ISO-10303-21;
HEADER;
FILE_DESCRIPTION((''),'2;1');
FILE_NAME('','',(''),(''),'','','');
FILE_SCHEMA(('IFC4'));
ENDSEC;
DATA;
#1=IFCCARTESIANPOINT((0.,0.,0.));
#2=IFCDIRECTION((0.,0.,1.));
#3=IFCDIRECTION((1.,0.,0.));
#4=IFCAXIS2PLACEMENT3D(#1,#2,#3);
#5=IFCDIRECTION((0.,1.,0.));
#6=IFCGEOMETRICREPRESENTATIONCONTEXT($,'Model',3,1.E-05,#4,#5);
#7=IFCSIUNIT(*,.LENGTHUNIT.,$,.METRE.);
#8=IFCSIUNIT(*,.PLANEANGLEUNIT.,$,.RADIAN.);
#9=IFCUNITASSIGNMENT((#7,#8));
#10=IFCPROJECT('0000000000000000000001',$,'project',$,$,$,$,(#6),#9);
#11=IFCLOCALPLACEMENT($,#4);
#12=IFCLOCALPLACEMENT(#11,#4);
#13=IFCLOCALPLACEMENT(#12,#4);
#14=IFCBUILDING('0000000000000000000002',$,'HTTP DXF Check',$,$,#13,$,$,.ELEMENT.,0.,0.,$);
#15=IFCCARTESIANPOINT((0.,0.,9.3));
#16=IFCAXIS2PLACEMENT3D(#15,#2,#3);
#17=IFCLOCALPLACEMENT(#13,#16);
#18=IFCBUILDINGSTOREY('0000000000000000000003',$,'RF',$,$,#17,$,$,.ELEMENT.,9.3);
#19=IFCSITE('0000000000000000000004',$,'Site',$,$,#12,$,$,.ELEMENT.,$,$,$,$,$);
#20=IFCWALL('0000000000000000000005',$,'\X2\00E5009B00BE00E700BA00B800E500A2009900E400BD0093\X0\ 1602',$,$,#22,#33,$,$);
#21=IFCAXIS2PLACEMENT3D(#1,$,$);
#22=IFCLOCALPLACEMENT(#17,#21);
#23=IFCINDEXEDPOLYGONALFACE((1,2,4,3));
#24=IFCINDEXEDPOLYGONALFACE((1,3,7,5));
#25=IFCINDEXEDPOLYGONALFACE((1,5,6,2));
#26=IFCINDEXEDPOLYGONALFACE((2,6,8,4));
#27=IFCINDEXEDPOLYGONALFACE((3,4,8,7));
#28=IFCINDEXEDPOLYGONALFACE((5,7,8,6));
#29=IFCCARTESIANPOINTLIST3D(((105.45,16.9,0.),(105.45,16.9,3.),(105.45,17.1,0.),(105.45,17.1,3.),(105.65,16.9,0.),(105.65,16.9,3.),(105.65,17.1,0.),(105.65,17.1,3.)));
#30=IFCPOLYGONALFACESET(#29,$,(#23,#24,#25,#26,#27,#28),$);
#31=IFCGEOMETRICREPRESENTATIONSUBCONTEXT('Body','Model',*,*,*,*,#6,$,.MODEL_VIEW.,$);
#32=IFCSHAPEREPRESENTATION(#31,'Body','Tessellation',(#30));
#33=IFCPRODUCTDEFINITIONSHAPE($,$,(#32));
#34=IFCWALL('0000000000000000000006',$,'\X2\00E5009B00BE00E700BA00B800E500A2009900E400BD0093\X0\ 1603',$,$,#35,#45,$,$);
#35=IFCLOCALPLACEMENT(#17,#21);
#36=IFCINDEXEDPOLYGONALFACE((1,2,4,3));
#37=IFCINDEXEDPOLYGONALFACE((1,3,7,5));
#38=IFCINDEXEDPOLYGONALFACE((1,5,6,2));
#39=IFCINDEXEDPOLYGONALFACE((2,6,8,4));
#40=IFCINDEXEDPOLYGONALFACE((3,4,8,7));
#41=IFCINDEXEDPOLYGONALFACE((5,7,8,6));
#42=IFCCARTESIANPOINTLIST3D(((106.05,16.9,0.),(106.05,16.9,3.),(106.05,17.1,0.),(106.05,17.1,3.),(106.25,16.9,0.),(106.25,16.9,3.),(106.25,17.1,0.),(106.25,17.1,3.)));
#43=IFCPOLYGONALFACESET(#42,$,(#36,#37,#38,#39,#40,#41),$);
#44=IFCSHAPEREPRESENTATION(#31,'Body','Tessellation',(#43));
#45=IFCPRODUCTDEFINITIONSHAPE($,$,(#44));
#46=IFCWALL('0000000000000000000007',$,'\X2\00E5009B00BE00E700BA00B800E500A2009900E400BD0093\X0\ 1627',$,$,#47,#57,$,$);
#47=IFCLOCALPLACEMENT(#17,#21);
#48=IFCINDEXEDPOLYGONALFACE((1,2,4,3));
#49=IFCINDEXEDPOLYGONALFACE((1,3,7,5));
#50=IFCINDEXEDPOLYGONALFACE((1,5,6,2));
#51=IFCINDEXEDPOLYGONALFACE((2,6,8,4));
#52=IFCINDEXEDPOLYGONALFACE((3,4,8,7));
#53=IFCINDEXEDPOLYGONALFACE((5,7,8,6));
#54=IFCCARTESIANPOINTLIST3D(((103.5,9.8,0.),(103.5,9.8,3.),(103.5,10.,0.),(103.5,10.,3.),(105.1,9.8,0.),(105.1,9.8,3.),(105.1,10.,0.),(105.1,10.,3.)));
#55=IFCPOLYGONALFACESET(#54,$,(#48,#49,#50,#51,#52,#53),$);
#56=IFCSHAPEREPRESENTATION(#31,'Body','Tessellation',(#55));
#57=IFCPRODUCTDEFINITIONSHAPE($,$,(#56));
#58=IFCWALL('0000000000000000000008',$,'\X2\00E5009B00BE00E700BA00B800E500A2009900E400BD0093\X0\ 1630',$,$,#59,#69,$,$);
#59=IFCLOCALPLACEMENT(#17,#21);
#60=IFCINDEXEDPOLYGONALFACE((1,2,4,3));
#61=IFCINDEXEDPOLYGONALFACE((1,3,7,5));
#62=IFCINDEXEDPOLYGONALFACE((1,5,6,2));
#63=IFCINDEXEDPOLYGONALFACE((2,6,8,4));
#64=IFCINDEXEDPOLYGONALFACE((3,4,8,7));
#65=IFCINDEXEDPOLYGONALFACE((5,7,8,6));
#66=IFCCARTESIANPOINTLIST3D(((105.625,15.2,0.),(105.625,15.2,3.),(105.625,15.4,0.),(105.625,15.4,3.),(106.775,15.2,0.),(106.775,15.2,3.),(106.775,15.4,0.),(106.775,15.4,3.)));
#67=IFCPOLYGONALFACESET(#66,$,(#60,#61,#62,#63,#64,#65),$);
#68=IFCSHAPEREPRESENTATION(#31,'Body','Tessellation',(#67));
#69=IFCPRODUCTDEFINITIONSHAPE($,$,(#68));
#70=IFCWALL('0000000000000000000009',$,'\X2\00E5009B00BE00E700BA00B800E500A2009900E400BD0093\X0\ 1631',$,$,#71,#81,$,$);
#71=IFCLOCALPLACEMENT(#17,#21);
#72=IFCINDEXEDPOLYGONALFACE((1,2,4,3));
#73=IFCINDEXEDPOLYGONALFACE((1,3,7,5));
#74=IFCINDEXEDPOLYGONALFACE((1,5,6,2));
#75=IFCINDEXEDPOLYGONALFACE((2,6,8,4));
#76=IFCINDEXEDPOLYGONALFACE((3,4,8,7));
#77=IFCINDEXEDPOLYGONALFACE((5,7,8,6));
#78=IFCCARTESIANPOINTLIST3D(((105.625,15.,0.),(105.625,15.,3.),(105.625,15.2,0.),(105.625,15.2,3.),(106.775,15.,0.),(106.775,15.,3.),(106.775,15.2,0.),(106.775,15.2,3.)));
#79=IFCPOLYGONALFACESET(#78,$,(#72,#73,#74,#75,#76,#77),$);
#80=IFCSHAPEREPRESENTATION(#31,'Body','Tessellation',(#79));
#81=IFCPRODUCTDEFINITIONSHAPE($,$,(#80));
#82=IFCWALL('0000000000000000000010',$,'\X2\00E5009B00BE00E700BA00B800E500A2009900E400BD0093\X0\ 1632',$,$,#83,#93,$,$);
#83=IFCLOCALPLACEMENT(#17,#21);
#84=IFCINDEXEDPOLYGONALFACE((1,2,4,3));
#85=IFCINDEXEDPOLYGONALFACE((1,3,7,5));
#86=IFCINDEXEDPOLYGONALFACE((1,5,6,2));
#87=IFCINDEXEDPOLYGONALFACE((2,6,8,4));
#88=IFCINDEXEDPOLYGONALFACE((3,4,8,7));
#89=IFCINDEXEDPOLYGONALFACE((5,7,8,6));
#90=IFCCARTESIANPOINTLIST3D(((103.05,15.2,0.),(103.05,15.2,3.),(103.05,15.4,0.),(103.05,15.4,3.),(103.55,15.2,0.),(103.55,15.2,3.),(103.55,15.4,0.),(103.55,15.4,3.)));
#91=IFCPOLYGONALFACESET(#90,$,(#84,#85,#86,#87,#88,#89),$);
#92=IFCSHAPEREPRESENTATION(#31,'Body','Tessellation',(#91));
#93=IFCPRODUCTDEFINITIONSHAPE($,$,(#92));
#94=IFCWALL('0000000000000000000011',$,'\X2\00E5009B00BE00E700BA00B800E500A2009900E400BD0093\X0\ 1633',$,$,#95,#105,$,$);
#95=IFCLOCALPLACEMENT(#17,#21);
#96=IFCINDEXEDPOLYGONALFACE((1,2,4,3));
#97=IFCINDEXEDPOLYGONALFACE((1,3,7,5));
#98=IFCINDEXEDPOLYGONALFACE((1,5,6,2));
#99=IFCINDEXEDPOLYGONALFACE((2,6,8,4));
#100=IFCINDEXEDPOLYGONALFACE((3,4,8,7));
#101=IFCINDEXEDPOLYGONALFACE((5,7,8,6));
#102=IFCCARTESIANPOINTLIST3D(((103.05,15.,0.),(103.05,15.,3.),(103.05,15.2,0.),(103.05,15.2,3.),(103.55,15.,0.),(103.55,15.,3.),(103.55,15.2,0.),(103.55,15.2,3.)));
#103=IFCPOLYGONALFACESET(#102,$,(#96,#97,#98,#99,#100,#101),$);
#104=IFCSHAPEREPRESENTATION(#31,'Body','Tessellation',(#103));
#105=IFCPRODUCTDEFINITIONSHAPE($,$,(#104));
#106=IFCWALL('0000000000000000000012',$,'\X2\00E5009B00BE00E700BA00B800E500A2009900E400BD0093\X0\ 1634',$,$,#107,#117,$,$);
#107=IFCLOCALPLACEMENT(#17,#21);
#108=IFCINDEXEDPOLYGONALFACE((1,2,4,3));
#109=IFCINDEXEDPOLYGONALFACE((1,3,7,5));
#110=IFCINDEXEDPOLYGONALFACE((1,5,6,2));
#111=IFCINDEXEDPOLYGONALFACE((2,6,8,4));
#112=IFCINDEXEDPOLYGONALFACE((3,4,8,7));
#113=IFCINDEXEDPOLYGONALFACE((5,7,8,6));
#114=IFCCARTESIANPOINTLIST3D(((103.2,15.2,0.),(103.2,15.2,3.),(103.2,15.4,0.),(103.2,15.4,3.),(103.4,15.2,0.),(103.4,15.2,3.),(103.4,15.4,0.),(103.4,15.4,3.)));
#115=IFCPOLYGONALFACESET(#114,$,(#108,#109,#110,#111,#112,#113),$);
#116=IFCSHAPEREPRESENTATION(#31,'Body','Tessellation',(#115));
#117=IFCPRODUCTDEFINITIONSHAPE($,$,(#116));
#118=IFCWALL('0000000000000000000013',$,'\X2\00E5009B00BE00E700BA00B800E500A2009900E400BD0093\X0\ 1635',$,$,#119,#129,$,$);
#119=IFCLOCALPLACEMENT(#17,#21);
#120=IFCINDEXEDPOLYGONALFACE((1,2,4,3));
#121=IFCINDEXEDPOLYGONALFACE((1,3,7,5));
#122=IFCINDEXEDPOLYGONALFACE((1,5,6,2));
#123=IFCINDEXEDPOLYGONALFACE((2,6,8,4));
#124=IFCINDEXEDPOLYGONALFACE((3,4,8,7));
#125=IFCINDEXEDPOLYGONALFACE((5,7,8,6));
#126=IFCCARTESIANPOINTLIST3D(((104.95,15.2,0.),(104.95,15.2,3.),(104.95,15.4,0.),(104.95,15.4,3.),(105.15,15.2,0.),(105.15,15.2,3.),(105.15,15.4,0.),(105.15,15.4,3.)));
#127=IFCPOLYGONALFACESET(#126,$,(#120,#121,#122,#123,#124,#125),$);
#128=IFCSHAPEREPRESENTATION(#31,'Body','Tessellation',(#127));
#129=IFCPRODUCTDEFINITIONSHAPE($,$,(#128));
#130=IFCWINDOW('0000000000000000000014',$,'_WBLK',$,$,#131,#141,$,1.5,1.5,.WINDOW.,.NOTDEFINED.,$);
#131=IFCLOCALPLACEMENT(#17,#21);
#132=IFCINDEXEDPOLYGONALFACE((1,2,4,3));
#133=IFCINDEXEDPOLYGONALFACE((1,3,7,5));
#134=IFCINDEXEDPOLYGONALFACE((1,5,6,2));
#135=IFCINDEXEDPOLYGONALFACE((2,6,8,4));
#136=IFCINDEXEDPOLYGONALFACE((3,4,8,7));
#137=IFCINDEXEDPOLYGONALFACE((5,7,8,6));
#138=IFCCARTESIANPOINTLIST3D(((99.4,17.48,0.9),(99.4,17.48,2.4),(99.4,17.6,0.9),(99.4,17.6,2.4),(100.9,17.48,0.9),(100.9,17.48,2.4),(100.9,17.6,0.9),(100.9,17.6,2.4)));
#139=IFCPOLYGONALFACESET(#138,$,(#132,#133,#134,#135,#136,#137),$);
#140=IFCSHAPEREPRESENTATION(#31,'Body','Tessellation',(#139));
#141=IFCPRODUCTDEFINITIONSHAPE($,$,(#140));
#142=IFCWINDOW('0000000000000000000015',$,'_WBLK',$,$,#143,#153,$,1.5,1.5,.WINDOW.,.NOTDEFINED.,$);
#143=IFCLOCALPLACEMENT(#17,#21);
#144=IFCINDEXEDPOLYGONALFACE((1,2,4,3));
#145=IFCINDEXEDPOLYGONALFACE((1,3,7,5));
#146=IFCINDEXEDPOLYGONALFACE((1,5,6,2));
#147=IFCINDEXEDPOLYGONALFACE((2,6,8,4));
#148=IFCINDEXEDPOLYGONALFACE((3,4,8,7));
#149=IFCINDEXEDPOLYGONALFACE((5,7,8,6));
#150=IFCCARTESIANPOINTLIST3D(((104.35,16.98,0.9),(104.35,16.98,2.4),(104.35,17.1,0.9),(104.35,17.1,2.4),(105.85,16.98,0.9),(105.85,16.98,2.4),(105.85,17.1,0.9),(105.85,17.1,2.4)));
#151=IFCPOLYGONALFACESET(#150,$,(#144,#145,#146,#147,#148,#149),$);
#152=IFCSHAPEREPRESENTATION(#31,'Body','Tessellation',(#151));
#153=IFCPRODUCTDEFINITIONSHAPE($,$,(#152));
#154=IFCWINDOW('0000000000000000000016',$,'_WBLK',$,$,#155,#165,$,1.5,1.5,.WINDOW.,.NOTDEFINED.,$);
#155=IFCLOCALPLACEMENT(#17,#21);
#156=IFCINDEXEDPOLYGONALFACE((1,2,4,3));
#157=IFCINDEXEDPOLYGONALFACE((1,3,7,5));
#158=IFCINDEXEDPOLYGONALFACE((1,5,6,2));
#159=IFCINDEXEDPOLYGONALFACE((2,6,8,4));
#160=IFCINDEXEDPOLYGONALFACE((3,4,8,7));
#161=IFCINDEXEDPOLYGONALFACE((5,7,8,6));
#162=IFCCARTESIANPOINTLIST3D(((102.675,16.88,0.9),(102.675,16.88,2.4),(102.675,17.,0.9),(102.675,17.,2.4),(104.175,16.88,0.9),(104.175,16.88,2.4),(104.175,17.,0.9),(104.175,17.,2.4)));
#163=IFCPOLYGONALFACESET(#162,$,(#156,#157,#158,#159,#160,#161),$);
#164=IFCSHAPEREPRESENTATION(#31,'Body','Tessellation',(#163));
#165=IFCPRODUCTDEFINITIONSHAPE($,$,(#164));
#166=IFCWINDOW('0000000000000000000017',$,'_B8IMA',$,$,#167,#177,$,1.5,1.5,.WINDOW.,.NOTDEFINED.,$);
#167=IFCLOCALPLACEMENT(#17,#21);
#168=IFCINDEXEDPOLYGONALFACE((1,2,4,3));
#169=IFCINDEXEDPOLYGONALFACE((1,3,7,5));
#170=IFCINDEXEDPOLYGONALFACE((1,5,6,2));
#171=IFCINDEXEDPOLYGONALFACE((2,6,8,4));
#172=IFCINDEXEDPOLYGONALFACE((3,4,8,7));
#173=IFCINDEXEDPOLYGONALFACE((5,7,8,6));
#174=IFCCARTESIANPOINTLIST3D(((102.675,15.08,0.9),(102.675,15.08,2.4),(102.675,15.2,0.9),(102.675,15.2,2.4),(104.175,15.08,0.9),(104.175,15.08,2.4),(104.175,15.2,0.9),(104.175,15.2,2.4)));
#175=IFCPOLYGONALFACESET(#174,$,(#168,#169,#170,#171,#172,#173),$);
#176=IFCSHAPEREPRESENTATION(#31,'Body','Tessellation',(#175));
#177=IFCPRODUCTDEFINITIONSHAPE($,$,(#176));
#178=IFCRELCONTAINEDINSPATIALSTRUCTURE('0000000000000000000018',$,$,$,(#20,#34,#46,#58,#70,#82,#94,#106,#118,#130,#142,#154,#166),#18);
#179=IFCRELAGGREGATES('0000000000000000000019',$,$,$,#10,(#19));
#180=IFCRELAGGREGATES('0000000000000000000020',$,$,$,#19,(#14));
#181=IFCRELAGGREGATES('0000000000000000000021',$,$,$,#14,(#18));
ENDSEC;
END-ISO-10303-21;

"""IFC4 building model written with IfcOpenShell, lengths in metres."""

from ifc_helpers import new_model, si_unit, direction, frame, frame_2d, origin_with_axes, place, context, subcontext, project, spatial, rectangle, extrude, element, save


model = new_model("IFC4")

# Units and contexts
model_context = context("Model", 3, precision=1e-05, world=origin_with_axes(), true_north=direction((0.0, 1.0, 0.0)))
body_context = subcontext(model_context, "Body", "Model", "MODEL_VIEW")
ifc_project = project(units=[si_unit("LENGTHUNIT", "METRE"), si_unit("PLANEANGLEUNIT", "RADIAN")], contexts=[model_context])

# Site, building, storey
placement = place(None, origin_with_axes())
site_placement = place(placement, origin_with_axes())
site = spatial("IfcSite", under=ifc_project, at=site_placement, Name="Site", CompositionType="ELEMENT")
building_placement = place(site_placement, origin_with_axes())
building = spatial("IfcBuilding", under=site, at=building_placement, Name="HTTP DXF Check", CompositionType="ELEMENT", ElevationOfRefHeight=0.0, ElevationOfTerrain=0.0)
storey_placement = place(building_placement, frame((0.0, 0.0, 9.3), z_axis=(0.0, 0.0, 1.0), x_axis=(1.0, 0.0, 0.0)))
storey = spatial("IfcBuildingStorey", under=building, at=storey_placement, Name="RF", CompositionType="ELEMENT", Elevation=9.3)

# Walls
for number, where, z_axis, x_axis, name in (
    (1, (105.55, 17.0, 0.0), (0.0, 0.0, 1.0), (0.0, 1.0, 0.0), "å\u009b¾çº¸å¢\u0099ä½\u0093 1602"),
    (2, (106.15, 17.0, 0.0), (0.0, 0.0, 1.0), (0.0, 1.0, 0.0), "å\u009b¾çº¸å¢\u0099ä½\u0093 1603"),
):
    element("IfcWall", number, at=place(storey_placement, frame(where, z_axis=z_axis, x_axis=x_axis)), inside=storey, Name=name, context=body_context, shape_type="SweptSolid", body=[
        extrude(rectangle(XDim=0.2, YDim=0.2, at=frame_2d((0.0, 0.0), x_axis=(1.0, 0.0, 0.0))), frame((0.0, 0.0, 0.0), z_axis=(0.0, 0.0, 1.0)), (0.0, 0.0, 1.0), 3.0),
    ])
wall_1_placement = place(storey_placement, frame((104.3, 9.9, 0.0), z_axis=(0.0, 0.0, 1.0), x_axis=(1.0, 0.0, 0.0)))
element("IfcWall", 3, at=wall_1_placement, inside=storey, Name="å\u009b¾çº¸å¢\u0099ä½\u0093 1627", context=body_context, shape_type="SweptSolid", body=[
    extrude(rectangle(XDim=1.6, YDim=0.2, at=frame_2d((0.0, 0.0), x_axis=(1.0, 0.0, 0.0))), frame((0.0, 0.0, 0.0), z_axis=(0.0, 0.0, 1.0)), (0.0, 0.0, 1.0), 3.0),
])
for number, where, z_axis, x_axis, name in (
    (4, (106.2, 15.3, 0.0), (0.0, 0.0, 1.0), (-1.0, 0.0, 0.0), "å\u009b¾çº¸å¢\u0099ä½\u0093 1630"),
    (5, (106.2, 15.1, 0.0), (0.0, 0.0, 1.0), (-1.0, 0.0, 0.0), "å\u009b¾çº¸å¢\u0099ä½\u0093 1631"),
):
    element("IfcWall", number, at=place(storey_placement, frame(where, z_axis=z_axis, x_axis=x_axis)), inside=storey, Name=name, context=body_context, shape_type="SweptSolid", body=[
        extrude(rectangle(XDim=1.15, YDim=0.2, at=frame_2d((0.0, 0.0), x_axis=(1.0, 0.0, 0.0))), frame((0.0, 0.0, 0.0), z_axis=(0.0, 0.0, 1.0)), (0.0, 0.0, 1.0), 3.0),
    ])
for number, where, z_axis, x_axis, name in (
    (6, (103.3, 15.3, 0.0), (0.0, 0.0, 1.0), (-1.0, 0.0, 0.0), "å\u009b¾çº¸å¢\u0099ä½\u0093 1632"),
    (7, (103.3, 15.1, 0.0), (0.0, 0.0, 1.0), (-1.0, 0.0, 0.0), "å\u009b¾çº¸å¢\u0099ä½\u0093 1633"),
):
    element("IfcWall", number, at=place(storey_placement, frame(where, z_axis=z_axis, x_axis=x_axis)), inside=storey, Name=name, context=body_context, shape_type="SweptSolid", body=[
        extrude(rectangle(XDim=0.5, YDim=0.2, at=frame_2d((0.0, 0.0), x_axis=(1.0, 0.0, 0.0))), frame((0.0, 0.0, 0.0), z_axis=(0.0, 0.0, 1.0)), (0.0, 0.0, 1.0), 3.0),
    ])
for number, where, z_axis, x_axis, name in (
    (8, (103.3, 15.3, 0.0), (0.0, 0.0, 1.0), (0.0, -1.0, 0.0), "å\u009b¾çº¸å¢\u0099ä½\u0093 1634"),
    (9, (105.05, 15.3, 0.0), (0.0, 0.0, 1.0), (0.0, -1.0, 0.0), "å\u009b¾çº¸å¢\u0099ä½\u0093 1635"),
):
    element("IfcWall", number, at=place(storey_placement, frame(where, z_axis=z_axis, x_axis=x_axis)), inside=storey, Name=name, context=body_context, shape_type="SweptSolid", body=[
        extrude(rectangle(XDim=0.2, YDim=0.2, at=frame_2d((0.0, 0.0), x_axis=(1.0, 0.0, 0.0))), frame((0.0, 0.0, 0.0), z_axis=(0.0, 0.0, 1.0)), (0.0, 0.0, 1.0), 3.0),
    ])

# Windows
for number, where, z_axis, x_axis, name in (
    (10, (100.15, 17.54, 0.9), (0.0, 0.0, 1.0), (1.0, 0.0, 0.0), "_WBLK"),
    (11, (105.1, 17.04, 0.9), (0.0, 0.0, 1.0), (1.0, 0.0, 0.0), "_WBLK"),
    (12, (103.425, 16.94, 0.9), (0.0, 0.0, 1.0), (1.0, 0.0, 0.0), "_WBLK"),
    (13, (103.425, 15.14, 0.9), (0.0, 0.0, 1.0), (1.0, 0.0, 0.0), "_B8IMA"),
):
    element("IfcWindow", number, at=place(storey_placement, frame(where, z_axis=z_axis, x_axis=x_axis)), inside=storey, Name=name, OverallHeight=1.5, OverallWidth=1.5, PartitioningType="NOTDEFINED", PredefinedType="WINDOW", context=body_context, shape_type="SweptSolid", body=[
        extrude(rectangle(XDim=1.5, YDim=0.12, at=frame_2d((0.0, 0.0), x_axis=(1.0, 0.0, 0.0))), frame((0.0, 0.0, 0.0), z_axis=(0.0, 0.0, 1.0)), (0.0, 0.0, 1.0), 1.5),
    ])

save(model, "model.ifc")
